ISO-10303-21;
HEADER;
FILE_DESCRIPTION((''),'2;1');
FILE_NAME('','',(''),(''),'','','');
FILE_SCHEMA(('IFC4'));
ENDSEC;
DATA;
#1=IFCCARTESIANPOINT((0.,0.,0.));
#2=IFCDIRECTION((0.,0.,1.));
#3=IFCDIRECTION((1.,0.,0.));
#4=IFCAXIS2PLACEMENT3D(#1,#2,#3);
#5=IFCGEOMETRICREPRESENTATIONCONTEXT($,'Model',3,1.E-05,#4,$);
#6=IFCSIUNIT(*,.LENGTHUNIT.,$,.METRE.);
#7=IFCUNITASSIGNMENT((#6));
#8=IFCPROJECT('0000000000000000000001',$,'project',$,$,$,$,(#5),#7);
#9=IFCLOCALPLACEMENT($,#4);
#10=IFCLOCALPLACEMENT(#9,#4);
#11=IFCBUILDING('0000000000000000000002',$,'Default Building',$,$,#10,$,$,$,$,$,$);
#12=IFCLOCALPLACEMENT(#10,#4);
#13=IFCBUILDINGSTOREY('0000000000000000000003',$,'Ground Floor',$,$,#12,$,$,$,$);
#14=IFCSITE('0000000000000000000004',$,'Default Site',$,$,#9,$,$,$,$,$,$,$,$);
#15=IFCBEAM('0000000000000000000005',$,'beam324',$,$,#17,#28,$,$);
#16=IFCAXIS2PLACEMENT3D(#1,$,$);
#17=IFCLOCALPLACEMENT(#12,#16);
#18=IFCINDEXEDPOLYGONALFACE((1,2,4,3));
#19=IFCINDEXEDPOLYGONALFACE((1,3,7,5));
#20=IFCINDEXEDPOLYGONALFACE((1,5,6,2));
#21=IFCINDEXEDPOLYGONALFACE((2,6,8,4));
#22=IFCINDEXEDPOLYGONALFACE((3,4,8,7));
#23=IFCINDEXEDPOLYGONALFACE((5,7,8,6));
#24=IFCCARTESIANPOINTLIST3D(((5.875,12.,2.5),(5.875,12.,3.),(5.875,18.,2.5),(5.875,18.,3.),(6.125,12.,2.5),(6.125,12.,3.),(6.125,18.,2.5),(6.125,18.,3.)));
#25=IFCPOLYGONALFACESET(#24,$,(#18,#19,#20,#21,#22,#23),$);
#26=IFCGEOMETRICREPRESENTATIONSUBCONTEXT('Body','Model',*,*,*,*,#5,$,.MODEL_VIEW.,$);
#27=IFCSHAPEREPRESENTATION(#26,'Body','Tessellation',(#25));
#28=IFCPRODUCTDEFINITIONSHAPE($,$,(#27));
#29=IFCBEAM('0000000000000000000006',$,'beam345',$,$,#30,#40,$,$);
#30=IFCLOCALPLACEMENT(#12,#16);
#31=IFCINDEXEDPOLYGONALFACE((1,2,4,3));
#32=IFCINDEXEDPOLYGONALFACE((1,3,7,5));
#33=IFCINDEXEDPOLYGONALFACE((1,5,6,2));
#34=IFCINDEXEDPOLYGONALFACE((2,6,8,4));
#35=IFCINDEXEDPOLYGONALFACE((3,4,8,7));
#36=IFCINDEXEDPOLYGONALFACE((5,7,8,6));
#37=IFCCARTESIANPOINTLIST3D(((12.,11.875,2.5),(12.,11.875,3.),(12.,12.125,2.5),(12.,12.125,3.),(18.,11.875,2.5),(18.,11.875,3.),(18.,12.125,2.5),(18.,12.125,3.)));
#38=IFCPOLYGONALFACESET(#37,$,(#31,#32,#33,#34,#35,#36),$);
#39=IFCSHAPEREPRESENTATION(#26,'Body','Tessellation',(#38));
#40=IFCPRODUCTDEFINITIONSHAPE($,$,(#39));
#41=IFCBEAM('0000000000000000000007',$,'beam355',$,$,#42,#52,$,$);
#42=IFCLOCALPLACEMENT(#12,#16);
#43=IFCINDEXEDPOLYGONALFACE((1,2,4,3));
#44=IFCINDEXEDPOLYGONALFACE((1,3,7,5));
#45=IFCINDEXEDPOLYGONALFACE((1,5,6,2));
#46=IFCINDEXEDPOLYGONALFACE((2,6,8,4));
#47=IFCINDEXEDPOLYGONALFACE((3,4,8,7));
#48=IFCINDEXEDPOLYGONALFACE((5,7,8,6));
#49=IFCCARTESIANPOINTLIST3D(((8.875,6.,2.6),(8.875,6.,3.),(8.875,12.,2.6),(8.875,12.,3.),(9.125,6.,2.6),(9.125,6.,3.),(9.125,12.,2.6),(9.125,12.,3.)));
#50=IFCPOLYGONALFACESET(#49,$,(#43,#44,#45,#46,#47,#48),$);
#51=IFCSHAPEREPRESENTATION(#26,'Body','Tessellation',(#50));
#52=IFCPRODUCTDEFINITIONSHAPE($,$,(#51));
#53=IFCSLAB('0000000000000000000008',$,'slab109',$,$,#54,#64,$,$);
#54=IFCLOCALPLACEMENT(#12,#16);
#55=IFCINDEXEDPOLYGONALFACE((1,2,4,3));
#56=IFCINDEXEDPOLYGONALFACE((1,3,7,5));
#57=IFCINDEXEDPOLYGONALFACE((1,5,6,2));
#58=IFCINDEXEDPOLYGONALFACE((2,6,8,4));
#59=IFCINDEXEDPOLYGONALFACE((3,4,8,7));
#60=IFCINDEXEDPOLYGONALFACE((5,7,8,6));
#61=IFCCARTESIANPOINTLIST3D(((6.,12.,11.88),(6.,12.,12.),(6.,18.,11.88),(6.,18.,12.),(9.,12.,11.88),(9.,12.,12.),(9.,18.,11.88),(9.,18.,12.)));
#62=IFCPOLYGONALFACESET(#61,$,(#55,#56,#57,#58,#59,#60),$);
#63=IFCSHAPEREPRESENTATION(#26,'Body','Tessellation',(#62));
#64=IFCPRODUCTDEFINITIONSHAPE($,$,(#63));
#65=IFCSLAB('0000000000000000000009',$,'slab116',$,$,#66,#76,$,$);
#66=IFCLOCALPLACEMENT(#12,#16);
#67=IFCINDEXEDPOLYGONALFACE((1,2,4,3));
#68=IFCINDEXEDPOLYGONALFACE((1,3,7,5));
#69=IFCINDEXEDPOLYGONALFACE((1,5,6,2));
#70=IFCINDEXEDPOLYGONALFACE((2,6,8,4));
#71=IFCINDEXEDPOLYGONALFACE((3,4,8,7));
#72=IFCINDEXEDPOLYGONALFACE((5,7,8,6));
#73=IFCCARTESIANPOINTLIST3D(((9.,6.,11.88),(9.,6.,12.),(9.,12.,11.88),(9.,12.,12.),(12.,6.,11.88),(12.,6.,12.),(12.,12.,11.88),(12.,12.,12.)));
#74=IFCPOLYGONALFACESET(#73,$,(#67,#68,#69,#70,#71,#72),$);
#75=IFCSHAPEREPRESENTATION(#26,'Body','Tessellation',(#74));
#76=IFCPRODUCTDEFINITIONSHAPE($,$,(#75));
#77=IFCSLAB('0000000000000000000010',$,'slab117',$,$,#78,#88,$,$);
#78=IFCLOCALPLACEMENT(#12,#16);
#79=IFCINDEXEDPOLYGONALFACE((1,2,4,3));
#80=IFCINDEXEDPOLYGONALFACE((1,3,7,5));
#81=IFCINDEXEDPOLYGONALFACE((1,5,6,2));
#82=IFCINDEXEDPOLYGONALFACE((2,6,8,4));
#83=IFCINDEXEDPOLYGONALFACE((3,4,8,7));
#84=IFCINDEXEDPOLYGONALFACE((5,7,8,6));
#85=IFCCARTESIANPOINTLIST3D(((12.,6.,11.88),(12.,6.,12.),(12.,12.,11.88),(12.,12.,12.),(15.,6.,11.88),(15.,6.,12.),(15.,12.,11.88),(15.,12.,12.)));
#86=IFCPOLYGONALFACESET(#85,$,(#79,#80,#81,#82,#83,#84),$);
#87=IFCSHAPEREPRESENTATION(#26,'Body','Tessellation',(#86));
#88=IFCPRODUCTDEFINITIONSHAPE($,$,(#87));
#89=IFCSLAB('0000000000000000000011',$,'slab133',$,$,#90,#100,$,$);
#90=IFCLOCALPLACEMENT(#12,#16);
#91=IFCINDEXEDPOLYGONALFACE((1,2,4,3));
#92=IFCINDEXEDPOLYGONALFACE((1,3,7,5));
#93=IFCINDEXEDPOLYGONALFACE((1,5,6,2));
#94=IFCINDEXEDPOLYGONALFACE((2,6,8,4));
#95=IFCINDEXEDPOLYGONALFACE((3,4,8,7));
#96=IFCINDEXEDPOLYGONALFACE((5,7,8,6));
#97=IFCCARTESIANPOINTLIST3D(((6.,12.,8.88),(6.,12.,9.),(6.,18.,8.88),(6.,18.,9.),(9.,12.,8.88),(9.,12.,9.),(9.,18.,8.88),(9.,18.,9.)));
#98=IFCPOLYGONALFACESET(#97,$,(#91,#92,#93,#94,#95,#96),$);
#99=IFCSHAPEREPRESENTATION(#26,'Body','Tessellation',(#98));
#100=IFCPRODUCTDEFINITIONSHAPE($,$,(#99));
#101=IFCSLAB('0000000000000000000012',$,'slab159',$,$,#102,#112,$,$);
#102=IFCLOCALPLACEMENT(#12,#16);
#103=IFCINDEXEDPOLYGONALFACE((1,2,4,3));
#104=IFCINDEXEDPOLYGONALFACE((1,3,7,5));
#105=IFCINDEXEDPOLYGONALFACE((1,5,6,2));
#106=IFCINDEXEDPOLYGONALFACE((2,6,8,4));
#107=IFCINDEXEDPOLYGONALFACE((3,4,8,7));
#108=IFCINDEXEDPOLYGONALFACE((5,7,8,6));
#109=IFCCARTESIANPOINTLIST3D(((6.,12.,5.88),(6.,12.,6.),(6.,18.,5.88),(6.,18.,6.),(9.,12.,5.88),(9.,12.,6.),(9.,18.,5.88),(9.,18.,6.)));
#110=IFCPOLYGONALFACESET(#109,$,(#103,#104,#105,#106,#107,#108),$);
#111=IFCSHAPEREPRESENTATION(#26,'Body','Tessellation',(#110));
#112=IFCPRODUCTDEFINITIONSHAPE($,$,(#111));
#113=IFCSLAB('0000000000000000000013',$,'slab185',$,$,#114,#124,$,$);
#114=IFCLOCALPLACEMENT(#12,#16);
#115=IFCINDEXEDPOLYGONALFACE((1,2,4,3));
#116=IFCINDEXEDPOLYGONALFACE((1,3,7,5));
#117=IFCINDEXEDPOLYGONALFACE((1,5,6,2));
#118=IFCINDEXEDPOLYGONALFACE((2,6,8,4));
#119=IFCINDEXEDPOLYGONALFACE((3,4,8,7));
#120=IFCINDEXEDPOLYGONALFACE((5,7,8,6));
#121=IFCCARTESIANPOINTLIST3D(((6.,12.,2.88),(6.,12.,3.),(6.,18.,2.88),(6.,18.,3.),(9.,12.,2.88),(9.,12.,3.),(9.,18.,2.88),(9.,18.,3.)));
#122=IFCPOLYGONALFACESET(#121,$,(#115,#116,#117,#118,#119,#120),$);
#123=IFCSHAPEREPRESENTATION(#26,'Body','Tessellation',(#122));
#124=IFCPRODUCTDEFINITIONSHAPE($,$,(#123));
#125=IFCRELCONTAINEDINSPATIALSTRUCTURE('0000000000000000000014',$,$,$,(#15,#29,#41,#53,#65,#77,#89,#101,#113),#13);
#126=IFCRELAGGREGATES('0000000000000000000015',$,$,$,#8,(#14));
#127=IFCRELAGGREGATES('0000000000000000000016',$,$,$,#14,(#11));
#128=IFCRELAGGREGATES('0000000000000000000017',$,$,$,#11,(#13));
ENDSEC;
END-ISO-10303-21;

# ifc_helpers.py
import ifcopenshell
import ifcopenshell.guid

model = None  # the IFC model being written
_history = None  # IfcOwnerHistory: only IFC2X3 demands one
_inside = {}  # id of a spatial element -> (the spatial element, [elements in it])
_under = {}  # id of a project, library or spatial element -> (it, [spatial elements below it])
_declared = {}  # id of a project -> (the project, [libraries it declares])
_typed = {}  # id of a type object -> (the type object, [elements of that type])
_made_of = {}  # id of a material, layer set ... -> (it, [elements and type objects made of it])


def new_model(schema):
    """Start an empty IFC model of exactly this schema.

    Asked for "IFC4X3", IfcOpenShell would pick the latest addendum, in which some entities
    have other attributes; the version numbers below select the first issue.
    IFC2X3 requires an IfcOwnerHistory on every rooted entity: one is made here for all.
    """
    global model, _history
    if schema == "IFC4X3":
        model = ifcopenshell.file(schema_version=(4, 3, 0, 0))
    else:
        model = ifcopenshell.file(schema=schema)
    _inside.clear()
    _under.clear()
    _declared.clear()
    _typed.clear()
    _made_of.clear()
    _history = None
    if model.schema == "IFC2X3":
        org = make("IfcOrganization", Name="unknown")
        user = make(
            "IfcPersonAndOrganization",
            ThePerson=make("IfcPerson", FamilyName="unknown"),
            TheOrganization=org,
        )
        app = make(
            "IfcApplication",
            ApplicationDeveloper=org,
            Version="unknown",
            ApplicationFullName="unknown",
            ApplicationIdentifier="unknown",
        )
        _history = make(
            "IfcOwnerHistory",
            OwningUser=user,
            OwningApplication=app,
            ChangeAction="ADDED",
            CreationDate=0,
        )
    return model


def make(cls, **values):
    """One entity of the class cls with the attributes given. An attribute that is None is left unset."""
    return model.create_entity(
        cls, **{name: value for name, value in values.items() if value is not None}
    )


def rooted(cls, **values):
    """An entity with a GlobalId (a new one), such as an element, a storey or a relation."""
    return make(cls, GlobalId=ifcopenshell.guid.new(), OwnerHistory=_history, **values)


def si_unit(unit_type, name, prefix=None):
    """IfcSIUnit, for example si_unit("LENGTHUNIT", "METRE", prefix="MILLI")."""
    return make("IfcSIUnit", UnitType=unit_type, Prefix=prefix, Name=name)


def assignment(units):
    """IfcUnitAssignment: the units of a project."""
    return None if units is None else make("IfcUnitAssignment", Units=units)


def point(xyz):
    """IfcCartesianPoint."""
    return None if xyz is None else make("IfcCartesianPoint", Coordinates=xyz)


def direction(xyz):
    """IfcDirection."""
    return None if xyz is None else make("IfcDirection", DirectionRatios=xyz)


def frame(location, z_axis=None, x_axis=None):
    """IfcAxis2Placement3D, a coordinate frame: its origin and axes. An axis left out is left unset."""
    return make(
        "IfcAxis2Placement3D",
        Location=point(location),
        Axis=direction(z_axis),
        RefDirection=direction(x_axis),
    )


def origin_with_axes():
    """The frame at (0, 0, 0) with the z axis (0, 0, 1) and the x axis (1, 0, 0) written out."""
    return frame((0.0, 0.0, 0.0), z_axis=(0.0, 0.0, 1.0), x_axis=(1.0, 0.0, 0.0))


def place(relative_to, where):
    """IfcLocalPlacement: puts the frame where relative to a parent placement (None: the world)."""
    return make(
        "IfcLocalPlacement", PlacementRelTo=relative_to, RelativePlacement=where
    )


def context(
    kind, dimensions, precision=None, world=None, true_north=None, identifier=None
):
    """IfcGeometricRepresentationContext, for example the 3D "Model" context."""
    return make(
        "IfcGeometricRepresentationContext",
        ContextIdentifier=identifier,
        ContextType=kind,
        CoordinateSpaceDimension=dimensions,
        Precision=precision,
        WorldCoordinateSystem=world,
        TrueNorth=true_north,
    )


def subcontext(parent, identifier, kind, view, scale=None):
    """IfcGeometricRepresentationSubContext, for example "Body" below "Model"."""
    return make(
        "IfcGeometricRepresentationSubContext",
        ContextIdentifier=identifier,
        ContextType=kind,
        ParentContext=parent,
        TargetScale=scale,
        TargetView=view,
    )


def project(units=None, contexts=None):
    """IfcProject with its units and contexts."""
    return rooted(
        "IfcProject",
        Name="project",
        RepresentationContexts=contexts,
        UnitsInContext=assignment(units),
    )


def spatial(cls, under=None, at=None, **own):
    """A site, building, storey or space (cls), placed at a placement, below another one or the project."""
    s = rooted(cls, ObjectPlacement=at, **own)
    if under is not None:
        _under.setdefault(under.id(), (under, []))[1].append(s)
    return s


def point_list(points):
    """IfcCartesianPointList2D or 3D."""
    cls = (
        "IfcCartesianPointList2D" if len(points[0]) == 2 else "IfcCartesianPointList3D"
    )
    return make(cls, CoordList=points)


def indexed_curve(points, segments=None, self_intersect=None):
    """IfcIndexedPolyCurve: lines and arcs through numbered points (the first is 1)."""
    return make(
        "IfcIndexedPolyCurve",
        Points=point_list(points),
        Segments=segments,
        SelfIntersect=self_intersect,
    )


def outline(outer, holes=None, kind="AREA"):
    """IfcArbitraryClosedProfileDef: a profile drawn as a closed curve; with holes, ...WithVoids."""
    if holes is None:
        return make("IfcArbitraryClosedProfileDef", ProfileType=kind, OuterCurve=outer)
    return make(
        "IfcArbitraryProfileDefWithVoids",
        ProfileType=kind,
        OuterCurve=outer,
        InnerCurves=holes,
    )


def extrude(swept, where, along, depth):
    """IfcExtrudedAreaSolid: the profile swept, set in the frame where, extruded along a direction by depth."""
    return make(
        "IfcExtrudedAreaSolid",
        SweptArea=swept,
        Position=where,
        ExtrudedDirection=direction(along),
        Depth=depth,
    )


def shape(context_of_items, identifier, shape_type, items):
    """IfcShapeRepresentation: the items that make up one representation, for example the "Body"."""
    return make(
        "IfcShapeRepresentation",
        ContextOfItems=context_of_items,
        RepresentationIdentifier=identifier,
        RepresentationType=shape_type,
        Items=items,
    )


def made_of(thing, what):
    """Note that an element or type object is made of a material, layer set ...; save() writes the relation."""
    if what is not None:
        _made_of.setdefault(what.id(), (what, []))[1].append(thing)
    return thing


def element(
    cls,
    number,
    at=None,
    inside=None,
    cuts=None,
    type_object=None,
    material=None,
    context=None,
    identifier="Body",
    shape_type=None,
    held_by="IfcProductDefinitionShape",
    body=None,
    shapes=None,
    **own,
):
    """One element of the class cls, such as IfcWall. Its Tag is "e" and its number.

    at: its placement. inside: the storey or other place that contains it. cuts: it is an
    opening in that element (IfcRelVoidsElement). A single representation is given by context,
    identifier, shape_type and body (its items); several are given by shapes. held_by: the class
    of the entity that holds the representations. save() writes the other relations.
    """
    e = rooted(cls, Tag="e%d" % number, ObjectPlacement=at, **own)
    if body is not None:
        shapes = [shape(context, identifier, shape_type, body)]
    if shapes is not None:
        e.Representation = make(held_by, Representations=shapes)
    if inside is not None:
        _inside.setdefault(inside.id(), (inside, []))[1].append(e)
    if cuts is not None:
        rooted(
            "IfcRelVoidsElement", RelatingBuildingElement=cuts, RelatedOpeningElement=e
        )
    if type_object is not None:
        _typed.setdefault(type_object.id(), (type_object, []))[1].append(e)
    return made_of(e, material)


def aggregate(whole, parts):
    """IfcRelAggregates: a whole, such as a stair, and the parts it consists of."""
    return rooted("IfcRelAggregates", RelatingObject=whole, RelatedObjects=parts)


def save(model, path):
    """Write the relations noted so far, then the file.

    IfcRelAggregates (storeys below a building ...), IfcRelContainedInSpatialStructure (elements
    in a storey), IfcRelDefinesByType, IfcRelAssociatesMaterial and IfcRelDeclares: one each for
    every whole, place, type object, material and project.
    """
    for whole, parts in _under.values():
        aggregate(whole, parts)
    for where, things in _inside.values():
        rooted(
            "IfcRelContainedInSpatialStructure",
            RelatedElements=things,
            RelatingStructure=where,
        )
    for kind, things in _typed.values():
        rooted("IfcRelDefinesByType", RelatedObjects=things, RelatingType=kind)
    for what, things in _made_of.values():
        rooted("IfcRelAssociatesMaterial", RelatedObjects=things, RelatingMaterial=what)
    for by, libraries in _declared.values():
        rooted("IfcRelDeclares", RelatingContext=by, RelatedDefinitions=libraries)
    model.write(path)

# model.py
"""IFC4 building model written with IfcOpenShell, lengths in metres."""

from ifc_helpers import new_model, si_unit, frame, origin_with_axes, place, context, subcontext, project, spatial, indexed_curve, outline, extrude, element, save


model = new_model("IFC4")

# Units and contexts
model_context = context("Model", 3, precision=1e-05, world=origin_with_axes())
body_context = subcontext(model_context, "Body", "Model", "MODEL_VIEW")
ifc_project = project(units=[si_unit("LENGTHUNIT", "METRE")], contexts=[model_context])

# Site, building, storey
site_placement = place(None, origin_with_axes())
site = spatial("IfcSite", under=ifc_project, at=site_placement, Name="Default Site")
building_placement = place(site_placement, origin_with_axes())
building = spatial("IfcBuilding", under=site, at=building_placement, Name="Default Building")
storey_placement = place(building_placement, origin_with_axes())
storey = spatial("IfcBuildingStorey", under=building, at=storey_placement, Name="Ground Floor")

# Beams
for number, where, z_axis, x_axis, name in (
    (1, (6.125, 12.0, 2.5), (0.0, 0.0, 1.0), (0.0, 1.0, 0.0), "beam324"),
    (2, (12.0, 11.875, 2.5), (0.0, 0.0, 1.0), (1.0, 0.0, 0.0), "beam345"),
):
    element("IfcBeam", number, at=place(storey_placement, frame(where, z_axis=z_axis, x_axis=x_axis)), inside=storey, Name=name, context=body_context, shape_type="SweptSolid", body=[
        extrude(outline(indexed_curve([(0.0, 0.0), (0.0, 0.25), (6.0, 0.25), (6.0, 0.0), (0.0, 0.0)], self_intersect=False)), origin_with_axes(), (0.0, 0.0, 1.0), 0.5),
    ])
beam_1_placement = place(storey_placement, frame((8.875, 12.0, 2.6), z_axis=(0.0, 0.0, 1.0), x_axis=(0.0, -1.0, 0.0)))
element("IfcBeam", 3, at=beam_1_placement, inside=storey, Name="beam355", context=body_context, shape_type="SweptSolid", body=[
    extrude(outline(indexed_curve([(0.0, 0.0), (0.0, 0.25), (6.0, 0.25), (6.0, 0.0), (0.0, 0.0)], self_intersect=False)), origin_with_axes(), (0.0, 0.0, 1.0), 0.4),
])

# Slabs
for number, where, z_axis, x_axis, name in (
    (4, (6.0, 12.0, 11.88), (0.0, 0.0, 1.0), (1.0, 0.0, 0.0), "slab109"),
    (5, (9.0, 6.0, 11.88), (0.0, 0.0, 1.0), (1.0, 0.0, 0.0), "slab116"),
    (6, (12.0, 6.0, 11.88), (0.0, 0.0, 1.0), (1.0, 0.0, 0.0), "slab117"),
    (7, (6.0, 12.0, 8.88), (0.0, 0.0, 1.0), (1.0, 0.0, 0.0), "slab133"),
    (8, (6.0, 12.0, 5.88), (0.0, 0.0, 1.0), (1.0, 0.0, 0.0), "slab159"),
    (9, (6.0, 12.0, 2.88), (0.0, 0.0, 1.0), (1.0, 0.0, 0.0), "slab185"),
):
    element("IfcSlab", number, at=place(storey_placement, frame(where, z_axis=z_axis, x_axis=x_axis)), inside=storey, Name=name, context=body_context, shape_type="SweptSolid", body=[
        extrude(outline(indexed_curve([(0.0, 0.0), (0.0, 6.0), (3.0, 6.0), (3.0, 0.0), (0.0, 0.0)], self_intersect=False)), origin_with_axes(), (0.0, 0.0, 1.0), 0.12),
    ])

save(model, "model.ifc")
